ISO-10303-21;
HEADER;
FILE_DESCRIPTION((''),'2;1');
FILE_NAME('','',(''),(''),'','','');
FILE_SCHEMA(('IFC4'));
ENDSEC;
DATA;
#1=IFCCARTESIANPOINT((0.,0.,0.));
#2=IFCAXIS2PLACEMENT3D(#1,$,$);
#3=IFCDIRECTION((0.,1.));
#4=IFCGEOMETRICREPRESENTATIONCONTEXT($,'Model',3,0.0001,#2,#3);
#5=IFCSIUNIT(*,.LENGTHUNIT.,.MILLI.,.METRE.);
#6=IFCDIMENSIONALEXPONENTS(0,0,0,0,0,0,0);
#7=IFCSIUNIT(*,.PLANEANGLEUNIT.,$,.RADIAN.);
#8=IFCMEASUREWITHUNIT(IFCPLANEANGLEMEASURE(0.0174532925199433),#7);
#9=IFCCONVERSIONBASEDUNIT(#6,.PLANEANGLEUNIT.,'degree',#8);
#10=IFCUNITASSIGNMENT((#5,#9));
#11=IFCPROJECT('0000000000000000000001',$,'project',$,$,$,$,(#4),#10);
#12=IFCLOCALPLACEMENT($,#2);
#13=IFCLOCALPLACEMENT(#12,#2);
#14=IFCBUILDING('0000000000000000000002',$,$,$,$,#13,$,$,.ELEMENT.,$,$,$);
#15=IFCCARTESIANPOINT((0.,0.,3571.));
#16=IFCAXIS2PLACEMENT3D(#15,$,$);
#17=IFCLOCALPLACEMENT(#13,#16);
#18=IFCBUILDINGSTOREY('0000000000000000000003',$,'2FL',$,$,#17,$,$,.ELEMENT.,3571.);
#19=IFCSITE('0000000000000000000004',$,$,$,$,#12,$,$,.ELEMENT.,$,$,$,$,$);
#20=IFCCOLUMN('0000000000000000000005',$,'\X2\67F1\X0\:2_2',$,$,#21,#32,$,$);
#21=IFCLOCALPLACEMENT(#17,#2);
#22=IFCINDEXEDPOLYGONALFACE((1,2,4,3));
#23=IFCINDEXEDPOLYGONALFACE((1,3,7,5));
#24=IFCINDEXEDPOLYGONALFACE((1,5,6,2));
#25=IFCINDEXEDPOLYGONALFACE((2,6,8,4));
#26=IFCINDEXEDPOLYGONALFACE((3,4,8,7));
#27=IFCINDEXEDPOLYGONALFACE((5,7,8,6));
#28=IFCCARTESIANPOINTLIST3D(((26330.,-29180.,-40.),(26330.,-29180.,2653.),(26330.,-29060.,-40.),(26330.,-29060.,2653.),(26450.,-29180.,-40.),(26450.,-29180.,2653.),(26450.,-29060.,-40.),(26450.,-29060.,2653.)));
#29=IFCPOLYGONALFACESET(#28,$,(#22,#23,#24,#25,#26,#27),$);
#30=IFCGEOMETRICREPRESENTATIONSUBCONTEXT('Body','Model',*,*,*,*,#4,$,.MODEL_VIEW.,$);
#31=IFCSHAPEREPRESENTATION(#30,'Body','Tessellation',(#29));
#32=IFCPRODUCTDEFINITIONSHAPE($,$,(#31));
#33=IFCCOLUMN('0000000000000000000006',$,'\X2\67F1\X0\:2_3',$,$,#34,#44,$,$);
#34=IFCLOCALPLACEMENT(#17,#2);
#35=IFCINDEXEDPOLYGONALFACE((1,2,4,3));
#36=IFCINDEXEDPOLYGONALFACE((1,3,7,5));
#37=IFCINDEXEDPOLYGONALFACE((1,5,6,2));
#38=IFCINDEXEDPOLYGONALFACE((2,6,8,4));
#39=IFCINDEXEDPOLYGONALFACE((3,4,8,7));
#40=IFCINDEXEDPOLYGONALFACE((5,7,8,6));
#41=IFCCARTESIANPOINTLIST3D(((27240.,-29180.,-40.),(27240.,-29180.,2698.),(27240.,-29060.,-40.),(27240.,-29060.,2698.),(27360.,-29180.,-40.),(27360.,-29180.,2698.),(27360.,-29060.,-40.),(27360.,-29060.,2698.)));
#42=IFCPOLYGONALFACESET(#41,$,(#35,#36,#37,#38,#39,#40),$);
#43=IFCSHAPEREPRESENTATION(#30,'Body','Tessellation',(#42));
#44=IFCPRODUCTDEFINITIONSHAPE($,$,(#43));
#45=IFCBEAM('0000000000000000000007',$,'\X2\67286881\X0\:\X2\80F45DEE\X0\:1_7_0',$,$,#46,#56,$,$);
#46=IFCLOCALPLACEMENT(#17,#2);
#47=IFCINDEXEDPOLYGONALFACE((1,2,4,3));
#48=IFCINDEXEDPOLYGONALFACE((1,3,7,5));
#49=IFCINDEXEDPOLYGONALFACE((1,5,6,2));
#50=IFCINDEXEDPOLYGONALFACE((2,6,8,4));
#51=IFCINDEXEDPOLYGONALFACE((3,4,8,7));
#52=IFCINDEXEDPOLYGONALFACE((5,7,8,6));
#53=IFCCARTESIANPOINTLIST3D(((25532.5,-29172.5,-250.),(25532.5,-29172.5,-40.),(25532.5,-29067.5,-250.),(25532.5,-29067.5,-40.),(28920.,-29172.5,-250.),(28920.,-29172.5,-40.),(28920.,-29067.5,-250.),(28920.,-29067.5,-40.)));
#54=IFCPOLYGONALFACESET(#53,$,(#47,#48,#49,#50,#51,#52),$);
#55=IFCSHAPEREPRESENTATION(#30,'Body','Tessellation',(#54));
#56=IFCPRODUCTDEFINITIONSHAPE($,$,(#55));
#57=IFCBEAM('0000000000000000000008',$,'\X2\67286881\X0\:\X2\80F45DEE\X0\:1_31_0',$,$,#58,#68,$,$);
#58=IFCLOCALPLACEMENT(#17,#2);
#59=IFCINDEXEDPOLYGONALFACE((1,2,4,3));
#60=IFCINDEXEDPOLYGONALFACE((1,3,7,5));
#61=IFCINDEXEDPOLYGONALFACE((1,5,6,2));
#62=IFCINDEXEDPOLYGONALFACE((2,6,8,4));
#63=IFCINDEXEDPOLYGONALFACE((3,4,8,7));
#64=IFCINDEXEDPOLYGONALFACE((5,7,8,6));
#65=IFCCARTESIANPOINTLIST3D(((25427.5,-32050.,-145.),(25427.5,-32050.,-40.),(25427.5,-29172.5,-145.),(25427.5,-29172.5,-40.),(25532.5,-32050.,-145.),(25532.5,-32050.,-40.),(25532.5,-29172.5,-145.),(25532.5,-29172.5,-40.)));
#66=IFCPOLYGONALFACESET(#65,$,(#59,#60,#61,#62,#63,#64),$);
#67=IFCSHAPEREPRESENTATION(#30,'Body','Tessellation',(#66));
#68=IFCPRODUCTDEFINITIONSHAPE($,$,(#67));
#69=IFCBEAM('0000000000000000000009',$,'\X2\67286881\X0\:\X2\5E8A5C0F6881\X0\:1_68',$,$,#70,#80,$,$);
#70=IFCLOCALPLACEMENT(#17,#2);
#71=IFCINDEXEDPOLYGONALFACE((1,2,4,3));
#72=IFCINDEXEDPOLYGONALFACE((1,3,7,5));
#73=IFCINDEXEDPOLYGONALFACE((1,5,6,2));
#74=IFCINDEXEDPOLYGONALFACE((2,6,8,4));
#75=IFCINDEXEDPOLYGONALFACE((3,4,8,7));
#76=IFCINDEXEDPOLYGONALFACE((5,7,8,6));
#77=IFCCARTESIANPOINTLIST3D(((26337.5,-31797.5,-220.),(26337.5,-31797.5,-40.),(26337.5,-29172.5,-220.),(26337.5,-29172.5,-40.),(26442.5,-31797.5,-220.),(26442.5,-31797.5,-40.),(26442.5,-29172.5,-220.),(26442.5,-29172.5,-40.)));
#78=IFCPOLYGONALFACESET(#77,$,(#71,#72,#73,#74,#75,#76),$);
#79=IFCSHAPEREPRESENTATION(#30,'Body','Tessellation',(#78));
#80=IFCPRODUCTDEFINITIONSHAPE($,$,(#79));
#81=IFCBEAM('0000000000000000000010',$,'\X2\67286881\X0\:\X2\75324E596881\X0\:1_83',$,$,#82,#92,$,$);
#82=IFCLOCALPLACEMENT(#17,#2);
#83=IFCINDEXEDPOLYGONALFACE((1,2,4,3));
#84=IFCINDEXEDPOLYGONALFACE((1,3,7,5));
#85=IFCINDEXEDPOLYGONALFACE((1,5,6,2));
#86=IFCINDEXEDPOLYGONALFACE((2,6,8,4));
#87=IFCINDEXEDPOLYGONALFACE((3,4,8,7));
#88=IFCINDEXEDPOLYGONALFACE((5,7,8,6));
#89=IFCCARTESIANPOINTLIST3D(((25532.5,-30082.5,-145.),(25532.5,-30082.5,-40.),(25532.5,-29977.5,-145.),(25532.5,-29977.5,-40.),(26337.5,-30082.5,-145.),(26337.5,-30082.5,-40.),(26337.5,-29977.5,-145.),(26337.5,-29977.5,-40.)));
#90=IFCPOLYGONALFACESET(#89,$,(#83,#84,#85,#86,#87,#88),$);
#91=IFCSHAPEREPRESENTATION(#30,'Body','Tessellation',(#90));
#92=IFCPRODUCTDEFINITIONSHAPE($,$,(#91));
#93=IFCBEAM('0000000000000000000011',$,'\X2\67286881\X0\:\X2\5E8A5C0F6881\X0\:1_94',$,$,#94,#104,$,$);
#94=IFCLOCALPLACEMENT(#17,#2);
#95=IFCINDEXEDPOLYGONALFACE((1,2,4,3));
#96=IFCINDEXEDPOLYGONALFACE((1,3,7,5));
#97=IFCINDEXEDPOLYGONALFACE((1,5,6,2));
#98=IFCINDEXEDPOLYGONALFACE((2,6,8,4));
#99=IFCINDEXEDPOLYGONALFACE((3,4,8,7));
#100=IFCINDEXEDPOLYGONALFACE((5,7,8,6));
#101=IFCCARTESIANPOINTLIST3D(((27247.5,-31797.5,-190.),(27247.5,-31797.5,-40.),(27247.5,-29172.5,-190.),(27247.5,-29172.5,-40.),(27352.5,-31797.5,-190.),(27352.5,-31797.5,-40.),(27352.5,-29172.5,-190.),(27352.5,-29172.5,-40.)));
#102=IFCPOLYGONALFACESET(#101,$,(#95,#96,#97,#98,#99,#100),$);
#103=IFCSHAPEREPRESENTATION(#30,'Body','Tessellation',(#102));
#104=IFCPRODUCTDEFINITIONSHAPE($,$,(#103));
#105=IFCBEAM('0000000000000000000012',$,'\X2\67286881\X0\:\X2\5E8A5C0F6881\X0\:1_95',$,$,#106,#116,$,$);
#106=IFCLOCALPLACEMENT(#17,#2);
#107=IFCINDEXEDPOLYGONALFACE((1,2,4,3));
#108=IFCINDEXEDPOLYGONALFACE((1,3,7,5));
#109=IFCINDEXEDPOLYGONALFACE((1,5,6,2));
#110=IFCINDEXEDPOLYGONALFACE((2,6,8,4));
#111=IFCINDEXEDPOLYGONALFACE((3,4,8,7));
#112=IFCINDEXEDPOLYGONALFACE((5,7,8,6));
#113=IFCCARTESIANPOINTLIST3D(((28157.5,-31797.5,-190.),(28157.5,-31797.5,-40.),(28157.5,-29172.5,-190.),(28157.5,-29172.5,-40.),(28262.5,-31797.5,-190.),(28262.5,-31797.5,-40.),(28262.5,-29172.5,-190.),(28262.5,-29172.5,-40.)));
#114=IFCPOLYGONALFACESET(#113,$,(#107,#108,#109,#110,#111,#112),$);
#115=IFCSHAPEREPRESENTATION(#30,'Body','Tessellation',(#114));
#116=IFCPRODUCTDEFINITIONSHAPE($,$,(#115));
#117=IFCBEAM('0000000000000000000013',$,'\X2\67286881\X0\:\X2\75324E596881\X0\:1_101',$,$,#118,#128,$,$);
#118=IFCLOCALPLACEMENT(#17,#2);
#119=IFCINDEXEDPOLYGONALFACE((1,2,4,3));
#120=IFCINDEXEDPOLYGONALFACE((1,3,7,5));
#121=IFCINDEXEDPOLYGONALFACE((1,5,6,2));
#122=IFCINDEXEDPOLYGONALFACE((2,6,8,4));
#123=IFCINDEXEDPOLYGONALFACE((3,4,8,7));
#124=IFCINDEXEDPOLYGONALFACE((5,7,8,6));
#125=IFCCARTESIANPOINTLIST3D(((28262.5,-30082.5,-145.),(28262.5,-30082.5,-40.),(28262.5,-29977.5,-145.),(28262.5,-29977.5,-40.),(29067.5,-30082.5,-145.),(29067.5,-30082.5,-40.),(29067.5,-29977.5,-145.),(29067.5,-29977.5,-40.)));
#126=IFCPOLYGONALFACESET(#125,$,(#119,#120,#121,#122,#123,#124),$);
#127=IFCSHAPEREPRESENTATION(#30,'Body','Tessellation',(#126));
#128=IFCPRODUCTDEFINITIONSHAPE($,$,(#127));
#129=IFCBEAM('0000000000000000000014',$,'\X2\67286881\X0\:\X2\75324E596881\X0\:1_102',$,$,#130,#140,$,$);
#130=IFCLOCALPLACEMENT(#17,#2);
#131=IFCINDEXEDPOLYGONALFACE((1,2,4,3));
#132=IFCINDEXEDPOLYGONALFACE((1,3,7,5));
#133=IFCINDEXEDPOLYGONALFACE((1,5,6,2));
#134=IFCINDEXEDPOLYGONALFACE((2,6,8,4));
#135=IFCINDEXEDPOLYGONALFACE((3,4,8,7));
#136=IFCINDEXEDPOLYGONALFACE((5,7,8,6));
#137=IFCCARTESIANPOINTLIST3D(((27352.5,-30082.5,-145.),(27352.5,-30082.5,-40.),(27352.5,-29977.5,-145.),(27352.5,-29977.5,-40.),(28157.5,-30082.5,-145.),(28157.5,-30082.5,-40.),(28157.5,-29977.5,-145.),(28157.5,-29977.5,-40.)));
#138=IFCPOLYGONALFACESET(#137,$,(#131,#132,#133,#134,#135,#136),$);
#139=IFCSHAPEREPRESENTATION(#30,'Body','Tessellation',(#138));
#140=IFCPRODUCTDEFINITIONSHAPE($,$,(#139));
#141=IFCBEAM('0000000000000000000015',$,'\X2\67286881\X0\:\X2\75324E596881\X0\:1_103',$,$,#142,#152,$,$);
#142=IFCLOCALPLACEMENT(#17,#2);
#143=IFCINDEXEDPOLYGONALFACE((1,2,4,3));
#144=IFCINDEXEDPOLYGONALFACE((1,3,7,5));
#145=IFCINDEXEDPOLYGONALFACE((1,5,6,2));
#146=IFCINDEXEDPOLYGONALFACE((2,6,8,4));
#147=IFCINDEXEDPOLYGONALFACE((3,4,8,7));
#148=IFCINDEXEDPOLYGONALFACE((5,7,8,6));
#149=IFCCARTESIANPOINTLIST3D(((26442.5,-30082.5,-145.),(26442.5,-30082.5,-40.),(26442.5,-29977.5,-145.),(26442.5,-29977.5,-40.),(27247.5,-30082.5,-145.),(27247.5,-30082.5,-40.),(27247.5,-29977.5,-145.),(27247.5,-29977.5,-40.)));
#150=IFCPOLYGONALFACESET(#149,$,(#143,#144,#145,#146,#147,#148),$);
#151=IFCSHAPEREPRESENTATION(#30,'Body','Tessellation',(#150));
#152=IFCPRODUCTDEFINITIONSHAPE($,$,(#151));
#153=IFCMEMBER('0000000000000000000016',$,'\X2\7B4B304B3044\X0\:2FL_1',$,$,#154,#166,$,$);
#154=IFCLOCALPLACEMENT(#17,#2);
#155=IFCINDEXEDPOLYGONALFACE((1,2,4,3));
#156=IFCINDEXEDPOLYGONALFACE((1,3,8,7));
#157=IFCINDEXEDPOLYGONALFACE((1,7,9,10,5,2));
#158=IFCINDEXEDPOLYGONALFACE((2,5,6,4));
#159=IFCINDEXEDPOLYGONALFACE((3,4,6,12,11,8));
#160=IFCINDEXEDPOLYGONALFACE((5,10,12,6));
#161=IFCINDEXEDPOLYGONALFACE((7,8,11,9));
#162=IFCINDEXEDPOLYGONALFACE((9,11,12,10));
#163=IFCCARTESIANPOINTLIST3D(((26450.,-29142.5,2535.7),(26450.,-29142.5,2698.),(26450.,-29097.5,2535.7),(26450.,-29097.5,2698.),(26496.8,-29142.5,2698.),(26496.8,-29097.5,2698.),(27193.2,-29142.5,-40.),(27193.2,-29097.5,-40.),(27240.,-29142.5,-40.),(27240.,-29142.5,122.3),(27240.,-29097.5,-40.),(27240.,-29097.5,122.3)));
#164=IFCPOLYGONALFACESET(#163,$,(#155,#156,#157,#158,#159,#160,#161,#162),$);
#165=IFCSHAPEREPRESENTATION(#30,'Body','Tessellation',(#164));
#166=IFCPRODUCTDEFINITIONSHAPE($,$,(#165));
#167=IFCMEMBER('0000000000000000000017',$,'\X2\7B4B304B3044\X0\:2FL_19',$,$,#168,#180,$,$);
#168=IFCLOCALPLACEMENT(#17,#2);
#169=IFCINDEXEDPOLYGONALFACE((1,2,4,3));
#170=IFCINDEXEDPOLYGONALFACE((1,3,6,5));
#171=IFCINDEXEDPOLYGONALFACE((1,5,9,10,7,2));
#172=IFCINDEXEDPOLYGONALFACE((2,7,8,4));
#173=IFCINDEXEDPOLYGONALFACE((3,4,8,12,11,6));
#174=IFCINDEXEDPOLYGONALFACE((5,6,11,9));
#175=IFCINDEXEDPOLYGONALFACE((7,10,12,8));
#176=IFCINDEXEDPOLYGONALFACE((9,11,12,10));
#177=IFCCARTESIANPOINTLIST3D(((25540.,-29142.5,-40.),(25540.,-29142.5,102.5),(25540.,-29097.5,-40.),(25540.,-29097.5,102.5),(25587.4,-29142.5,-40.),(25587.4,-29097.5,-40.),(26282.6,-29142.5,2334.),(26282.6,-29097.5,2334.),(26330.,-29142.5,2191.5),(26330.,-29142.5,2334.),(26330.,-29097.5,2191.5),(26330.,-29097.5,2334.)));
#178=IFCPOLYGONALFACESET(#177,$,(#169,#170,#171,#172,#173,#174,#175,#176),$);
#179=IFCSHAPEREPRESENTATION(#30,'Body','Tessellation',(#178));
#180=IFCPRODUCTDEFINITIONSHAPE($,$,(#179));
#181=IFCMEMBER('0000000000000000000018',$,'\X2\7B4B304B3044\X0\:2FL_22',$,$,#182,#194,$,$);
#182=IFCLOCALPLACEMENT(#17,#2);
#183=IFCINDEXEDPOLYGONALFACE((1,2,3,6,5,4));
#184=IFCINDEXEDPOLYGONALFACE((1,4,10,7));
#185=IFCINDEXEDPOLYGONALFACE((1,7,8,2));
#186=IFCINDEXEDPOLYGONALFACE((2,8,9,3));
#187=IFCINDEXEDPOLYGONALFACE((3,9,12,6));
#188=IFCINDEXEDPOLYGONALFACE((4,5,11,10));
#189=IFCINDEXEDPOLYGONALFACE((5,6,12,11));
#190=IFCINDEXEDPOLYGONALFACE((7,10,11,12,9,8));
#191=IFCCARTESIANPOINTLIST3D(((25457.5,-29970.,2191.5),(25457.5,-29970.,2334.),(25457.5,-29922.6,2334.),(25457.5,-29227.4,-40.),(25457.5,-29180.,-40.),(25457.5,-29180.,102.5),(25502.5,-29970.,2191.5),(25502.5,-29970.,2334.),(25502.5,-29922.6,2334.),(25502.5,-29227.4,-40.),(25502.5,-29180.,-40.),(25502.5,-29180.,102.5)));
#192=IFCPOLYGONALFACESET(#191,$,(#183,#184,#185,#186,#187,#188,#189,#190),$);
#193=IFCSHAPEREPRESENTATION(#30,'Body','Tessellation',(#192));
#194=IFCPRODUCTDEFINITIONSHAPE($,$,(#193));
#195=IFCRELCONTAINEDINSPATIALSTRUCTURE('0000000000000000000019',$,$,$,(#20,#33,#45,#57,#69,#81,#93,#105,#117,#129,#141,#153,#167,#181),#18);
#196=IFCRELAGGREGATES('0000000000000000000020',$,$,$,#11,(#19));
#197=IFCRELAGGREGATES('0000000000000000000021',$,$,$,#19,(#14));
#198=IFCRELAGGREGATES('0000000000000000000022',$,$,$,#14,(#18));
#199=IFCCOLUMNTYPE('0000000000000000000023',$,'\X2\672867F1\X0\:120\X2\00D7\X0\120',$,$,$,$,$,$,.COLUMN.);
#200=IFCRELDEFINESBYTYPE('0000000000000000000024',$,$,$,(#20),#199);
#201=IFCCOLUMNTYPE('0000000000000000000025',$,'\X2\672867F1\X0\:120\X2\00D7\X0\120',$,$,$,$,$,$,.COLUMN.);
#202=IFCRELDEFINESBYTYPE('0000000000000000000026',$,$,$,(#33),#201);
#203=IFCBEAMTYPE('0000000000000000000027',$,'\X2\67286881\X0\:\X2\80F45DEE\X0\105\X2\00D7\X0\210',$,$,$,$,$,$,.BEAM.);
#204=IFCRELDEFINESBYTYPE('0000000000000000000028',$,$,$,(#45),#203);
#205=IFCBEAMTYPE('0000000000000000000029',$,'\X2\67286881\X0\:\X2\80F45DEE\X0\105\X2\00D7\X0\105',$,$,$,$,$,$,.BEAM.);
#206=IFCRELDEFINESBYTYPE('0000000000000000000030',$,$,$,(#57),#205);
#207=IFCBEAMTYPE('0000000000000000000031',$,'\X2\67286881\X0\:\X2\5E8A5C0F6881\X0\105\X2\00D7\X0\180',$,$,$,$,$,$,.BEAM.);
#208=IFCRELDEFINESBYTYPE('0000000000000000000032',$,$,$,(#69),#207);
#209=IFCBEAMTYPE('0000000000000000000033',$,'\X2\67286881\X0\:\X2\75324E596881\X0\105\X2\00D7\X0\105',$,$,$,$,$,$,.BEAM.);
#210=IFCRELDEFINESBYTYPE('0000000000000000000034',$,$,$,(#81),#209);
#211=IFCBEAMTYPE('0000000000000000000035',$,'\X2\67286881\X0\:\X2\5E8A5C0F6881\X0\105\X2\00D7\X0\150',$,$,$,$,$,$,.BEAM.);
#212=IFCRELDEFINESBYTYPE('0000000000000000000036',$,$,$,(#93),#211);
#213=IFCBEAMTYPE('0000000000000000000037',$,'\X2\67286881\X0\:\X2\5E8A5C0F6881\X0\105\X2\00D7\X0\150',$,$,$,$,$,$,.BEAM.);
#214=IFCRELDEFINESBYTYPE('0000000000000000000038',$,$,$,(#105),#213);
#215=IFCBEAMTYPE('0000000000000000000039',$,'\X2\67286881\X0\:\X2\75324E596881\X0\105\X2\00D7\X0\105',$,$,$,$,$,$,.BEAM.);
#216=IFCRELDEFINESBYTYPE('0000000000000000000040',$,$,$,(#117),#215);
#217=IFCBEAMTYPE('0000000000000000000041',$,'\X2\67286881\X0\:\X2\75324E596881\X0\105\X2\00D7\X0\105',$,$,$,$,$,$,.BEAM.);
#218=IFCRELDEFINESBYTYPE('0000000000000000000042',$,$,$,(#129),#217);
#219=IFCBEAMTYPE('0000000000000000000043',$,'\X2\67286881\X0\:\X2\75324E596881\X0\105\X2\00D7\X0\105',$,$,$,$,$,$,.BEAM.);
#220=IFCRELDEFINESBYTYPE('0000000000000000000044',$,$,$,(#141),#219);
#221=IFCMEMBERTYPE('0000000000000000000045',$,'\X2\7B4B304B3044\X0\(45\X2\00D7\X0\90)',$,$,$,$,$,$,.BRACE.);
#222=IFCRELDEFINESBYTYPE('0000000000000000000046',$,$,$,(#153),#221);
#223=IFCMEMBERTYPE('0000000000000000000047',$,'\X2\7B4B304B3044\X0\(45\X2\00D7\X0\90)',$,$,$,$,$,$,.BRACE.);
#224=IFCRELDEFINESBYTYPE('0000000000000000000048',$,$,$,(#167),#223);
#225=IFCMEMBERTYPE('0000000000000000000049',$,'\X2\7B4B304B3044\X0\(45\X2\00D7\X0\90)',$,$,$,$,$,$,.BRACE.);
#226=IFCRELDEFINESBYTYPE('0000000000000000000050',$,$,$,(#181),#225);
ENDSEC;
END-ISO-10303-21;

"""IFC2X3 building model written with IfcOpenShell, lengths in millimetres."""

from ifc_helpers import new_model, entity, si_unit, converted_unit, direction, frame, origin, origin_with_axes, origin_2d, place, context, subcontext, project, spatial, polyline, rectangle, outline, extrude, type_object, element, save


model = new_model("IFC2X3")

# Units and contexts
model_context = context("Model", 3, precision=0.0001, world=origin(), true_north=direction((0.0, 1.0)))
body_context = subcontext(model_context, "Body", "Model", "MODEL_VIEW")
ifc_project = project(units=[si_unit("LENGTHUNIT", "METRE", prefix="MILLI"), converted_unit("PLANEANGLEUNIT", "degree", entity("IfcPlaneAngleMeasure", 0.0174532925199433), si_unit("PLANEANGLEUNIT", "RADIAN"), dimensions=[0, 0, 0, 0, 0, 0, 0])], contexts=[model_context])

# Site, building, storey
site_placement = place(None, origin())
site = spatial("IfcSite", under=ifc_project, at=site_placement, CompositionType="ELEMENT")
building_placement = place(site_placement, origin())
building = spatial("IfcBuilding", under=site, at=building_placement, CompositionType="ELEMENT")
storey_placement = place(building_placement, frame((0.0, 0.0, 3571.0)))
storey = spatial("IfcBuildingStorey", under=building, at=storey_placement, Name="2FL", CompositionType="ELEMENT", Elevation=3571.0)

# Columns
column_type_1 = type_object("IfcColumnType", Name="木柱:120×120", PredefinedType="COLUMN")
column_1_placement = place(storey_placement, frame((26390.0, -29120.0, -40.0)))
element("IfcColumn", 1, at=column_1_placement, inside=storey, type_object=column_type_1, Name="柱:2_2", context=body_context, shape_type="SweptSolid", body=[
    extrude(rectangle(XDim=120.0, YDim=120.0, at=origin_2d()), origin_with_axes(), (0.0, 0.0, 1.0), 2693.0),
])
column_type_2 = type_object("IfcColumnType", Name="木柱:120×120", PredefinedType="COLUMN")
column_2_placement = place(storey_placement, frame((27300.0, -29120.0, -40.0)))
element("IfcColumn", 2, at=column_2_placement, inside=storey, type_object=column_type_2, Name="柱:2_3", context=body_context, shape_type="SweptSolid", body=[
    extrude(rectangle(XDim=120.0, YDim=120.0, at=origin_2d()), origin_with_axes(), (0.0, 0.0, 1.0), 2738.0),
])

# Beams
beam_type_1 = type_object("IfcBeamType", Name="木梁:胴差105×210", PredefinedType="BEAM")
beam_1_placement = place(storey_placement, frame((25532.5, -29120.0, -145.0), z_axis=(1.0, 0.0, 0.0), x_axis=(0.0, 1.0, 0.0)))
element("IfcBeam", 3, at=beam_1_placement, inside=storey, type_object=beam_type_1, Name="木梁:胴差:1_7_0", context=body_context, shape_type="SweptSolid", body=[
    extrude(rectangle(XDim=105.0, YDim=210.0, at=origin_2d()), origin_with_axes(), (0.0, 0.0, 1.0), 3387.5),
])
beam_type_2 = type_object("IfcBeamType", Name="木梁:胴差105×105", PredefinedType="BEAM")
beam_2_placement = place(storey_placement, frame((25480.0, -29172.5, -92.5), z_axis=(0.0, -1.0, 0.0), x_axis=(1.0, 0.0, 0.0)))
element("IfcBeam", 4, at=beam_2_placement, inside=storey, type_object=beam_type_2, Name="木梁:胴差:1_31_0", context=body_context, shape_type="SweptSolid", body=[
    extrude(rectangle(XDim=105.0, YDim=105.0, at=origin_2d()), origin_with_axes(), (0.0, 0.0, 1.0), 2877.5),
])
beam_type_3 = type_object("IfcBeamType", Name="木梁:床小梁105×180", PredefinedType="BEAM")
beam_3_placement = place(storey_placement, frame((26390.0, -29172.5, -130.0), z_axis=(0.0, -1.0, 0.0), x_axis=(1.0, 0.0, 0.0)))
element("IfcBeam", 5, at=beam_3_placement, inside=storey, type_object=beam_type_3, Name="木梁:床小梁:1_68", context=body_context, shape_type="SweptSolid", body=[
    extrude(rectangle(XDim=105.0, YDim=180.0, at=origin_2d()), origin_with_axes(), (0.0, 0.0, 1.0), 2625.0),
])
beam_type_4 = type_object("IfcBeamType", Name="木梁:甲乙梁105×105", PredefinedType="BEAM")
beam_4_placement = place(storey_placement, frame((25532.5, -30030.0, -92.5), z_axis=(1.0, 0.0, 0.0), x_axis=(0.0, 1.0, 0.0)))
element("IfcBeam", 6, at=beam_4_placement, inside=storey, type_object=beam_type_4, Name="木梁:甲乙梁:1_83", context=body_context, shape_type="SweptSolid", body=[
    extrude(rectangle(XDim=105.0, YDim=105.0, at=origin_2d()), origin_with_axes(), (0.0, 0.0, 1.0), 805.0),
])
beam_type_5 = type_object("IfcBeamType", Name="木梁:床小梁105×150", PredefinedType="BEAM")
beam_5_placement = place(storey_placement, frame((27300.0, -29172.5, -115.0), z_axis=(0.0, -1.0, 0.0), x_axis=(1.0, 0.0, 0.0)))
element("IfcBeam", 7, at=beam_5_placement, inside=storey, type_object=beam_type_5, Name="木梁:床小梁:1_94", context=body_context, shape_type="SweptSolid", body=[
    extrude(rectangle(XDim=105.0, YDim=150.0, at=origin_2d()), origin_with_axes(), (0.0, 0.0, 1.0), 2625.0),
])
beam_type_6 = type_object("IfcBeamType", Name="木梁:床小梁105×150", PredefinedType="BEAM")
beam_6_placement = place(storey_placement, frame((28210.0, -29172.5, -115.0), z_axis=(0.0, -1.0, 0.0), x_axis=(1.0, 0.0, 0.0)))
element("IfcBeam", 8, at=beam_6_placement, inside=storey, type_object=beam_type_6, Name="木梁:床小梁:1_95", context=body_context, shape_type="SweptSolid", body=[
    extrude(rectangle(XDim=105.0, YDim=150.0, at=origin_2d()), origin_with_axes(), (0.0, 0.0, 1.0), 2625.0),
])
beam_type_7 = type_object("IfcBeamType", Name="木梁:甲乙梁105×105", PredefinedType="BEAM")
beam_7_placement = place(storey_placement, frame((28262.5, -30030.0, -92.5), z_axis=(1.0, 0.0, 0.0), x_axis=(0.0, 1.0, 0.0)))
element("IfcBeam", 9, at=beam_7_placement, inside=storey, type_object=beam_type_7, Name="木梁:甲乙梁:1_101", context=body_context, shape_type="SweptSolid", body=[
    extrude(rectangle(XDim=105.0, YDim=105.0, at=origin_2d()), origin_with_axes(), (0.0, 0.0, 1.0), 805.0),
])
beam_type_8 = type_object("IfcBeamType", Name="木梁:甲乙梁105×105", PredefinedType="BEAM")
beam_8_placement = place(storey_placement, frame((27352.5, -30030.0, -92.5), z_axis=(1.0, 0.0, 0.0), x_axis=(0.0, 1.0, 0.0)))
element("IfcBeam", 10, at=beam_8_placement, inside=storey, type_object=beam_type_8, Name="木梁:甲乙梁:1_102", context=body_context, shape_type="SweptSolid", body=[
    extrude(rectangle(XDim=105.0, YDim=105.0, at=origin_2d()), origin_with_axes(), (0.0, 0.0, 1.0), 805.0),
])
beam_type_9 = type_object("IfcBeamType", Name="木梁:甲乙梁105×105", PredefinedType="BEAM")
beam_9_placement = place(storey_placement, frame((26442.5, -30030.0, -92.5), z_axis=(1.0, 0.0, 0.0), x_axis=(0.0, 1.0, 0.0)))
element("IfcBeam", 11, at=beam_9_placement, inside=storey, type_object=beam_type_9, Name="木梁:甲乙梁:1_103", context=body_context, shape_type="SweptSolid", body=[
    extrude(rectangle(XDim=105.0, YDim=105.0, at=origin_2d()), origin_with_axes(), (0.0, 0.0, 1.0), 805.0),
])

# Members
member_type_1 = type_object("IfcMemberType", Name="筋かい(45×90)", PredefinedType="BRACE")
member_1_placement = place(storey_placement, frame((27240.0, -29120.0, -40.0), z_axis=(-0.277223, 0.0, 0.960806), x_axis=(0.960806, 0.0, 0.277223)))
element("IfcMember", 12, at=member_1_placement, inside=storey, type_object=member_type_1, Name="筋かい:2FL_1", context=body_context, shape_type="SweptSolid", body=[
    extrude(outline(polyline([(0.0, 0.0), (13.0, -45.0), (2693.7, -45.0), (2849.7, 0.0), (2836.7, 45.0), (156.0, 45.0), (0.0, 0.0)])), frame((0.0, -22.5, 0.0), z_axis=(0.0, 1.0, 0.0), x_axis=(0.0, 0.0, 1.0)), (0.0, 0.0, 1.0), 45.0),
])
member_type_2 = type_object("IfcMemberType", Name="筋かい(45×90)", PredefinedType="BRACE")
member_2_placement = place(storey_placement, frame((25540.0, -29120.0, -40.0), z_axis=(0.315748, 0.0, 0.948843), x_axis=(-0.948843, 0.0, 0.315748)))
element("IfcMember", 13, at=member_2_placement, inside=storey, type_object=member_type_2, Name="筋かい:2FL_19", context=body_context, shape_type="SweptSolid", body=[
    extrude(outline(polyline([(0.0, 0.0), (15.0, -45.0), (2366.8, -45.0), (2502.0, 0.0), (2487.0, 45.0), (135.2, 45.0), (0.0, 0.0)])), frame((0.0, -22.5, 0.0), z_axis=(0.0, 1.0, 0.0), x_axis=(0.0, 0.0, 1.0)), (0.0, 0.0, 1.0), 45.0),
])
member_type_3 = type_object("IfcMemberType", Name="筋かい(45×90)", PredefinedType="BRACE")
member_3_placement = place(storey_placement, frame((25480.0, -29180.0, -40.0), z_axis=(0.0, -0.315748, 0.948843), x_axis=(0.0, 0.948843, 0.315748)))
element("IfcMember", 14, at=member_3_placement, inside=storey, type_object=member_type_3, Name="筋かい:2FL_22", context=body_context, shape_type="SweptSolid", body=[
    extrude(outline(polyline([(0.0, 0.0), (15.0, -45.0), (2366.8, -45.0), (2502.0, 0.0), (2487.0, 45.0), (135.2, 45.0), (0.0, 0.0)])), frame((0.0, -22.5, 0.0), z_axis=(0.0, 1.0, 0.0), x_axis=(0.0, 0.0, 1.0)), (0.0, 0.0, 1.0), 45.0),
])

save(model, "model.ifc")
